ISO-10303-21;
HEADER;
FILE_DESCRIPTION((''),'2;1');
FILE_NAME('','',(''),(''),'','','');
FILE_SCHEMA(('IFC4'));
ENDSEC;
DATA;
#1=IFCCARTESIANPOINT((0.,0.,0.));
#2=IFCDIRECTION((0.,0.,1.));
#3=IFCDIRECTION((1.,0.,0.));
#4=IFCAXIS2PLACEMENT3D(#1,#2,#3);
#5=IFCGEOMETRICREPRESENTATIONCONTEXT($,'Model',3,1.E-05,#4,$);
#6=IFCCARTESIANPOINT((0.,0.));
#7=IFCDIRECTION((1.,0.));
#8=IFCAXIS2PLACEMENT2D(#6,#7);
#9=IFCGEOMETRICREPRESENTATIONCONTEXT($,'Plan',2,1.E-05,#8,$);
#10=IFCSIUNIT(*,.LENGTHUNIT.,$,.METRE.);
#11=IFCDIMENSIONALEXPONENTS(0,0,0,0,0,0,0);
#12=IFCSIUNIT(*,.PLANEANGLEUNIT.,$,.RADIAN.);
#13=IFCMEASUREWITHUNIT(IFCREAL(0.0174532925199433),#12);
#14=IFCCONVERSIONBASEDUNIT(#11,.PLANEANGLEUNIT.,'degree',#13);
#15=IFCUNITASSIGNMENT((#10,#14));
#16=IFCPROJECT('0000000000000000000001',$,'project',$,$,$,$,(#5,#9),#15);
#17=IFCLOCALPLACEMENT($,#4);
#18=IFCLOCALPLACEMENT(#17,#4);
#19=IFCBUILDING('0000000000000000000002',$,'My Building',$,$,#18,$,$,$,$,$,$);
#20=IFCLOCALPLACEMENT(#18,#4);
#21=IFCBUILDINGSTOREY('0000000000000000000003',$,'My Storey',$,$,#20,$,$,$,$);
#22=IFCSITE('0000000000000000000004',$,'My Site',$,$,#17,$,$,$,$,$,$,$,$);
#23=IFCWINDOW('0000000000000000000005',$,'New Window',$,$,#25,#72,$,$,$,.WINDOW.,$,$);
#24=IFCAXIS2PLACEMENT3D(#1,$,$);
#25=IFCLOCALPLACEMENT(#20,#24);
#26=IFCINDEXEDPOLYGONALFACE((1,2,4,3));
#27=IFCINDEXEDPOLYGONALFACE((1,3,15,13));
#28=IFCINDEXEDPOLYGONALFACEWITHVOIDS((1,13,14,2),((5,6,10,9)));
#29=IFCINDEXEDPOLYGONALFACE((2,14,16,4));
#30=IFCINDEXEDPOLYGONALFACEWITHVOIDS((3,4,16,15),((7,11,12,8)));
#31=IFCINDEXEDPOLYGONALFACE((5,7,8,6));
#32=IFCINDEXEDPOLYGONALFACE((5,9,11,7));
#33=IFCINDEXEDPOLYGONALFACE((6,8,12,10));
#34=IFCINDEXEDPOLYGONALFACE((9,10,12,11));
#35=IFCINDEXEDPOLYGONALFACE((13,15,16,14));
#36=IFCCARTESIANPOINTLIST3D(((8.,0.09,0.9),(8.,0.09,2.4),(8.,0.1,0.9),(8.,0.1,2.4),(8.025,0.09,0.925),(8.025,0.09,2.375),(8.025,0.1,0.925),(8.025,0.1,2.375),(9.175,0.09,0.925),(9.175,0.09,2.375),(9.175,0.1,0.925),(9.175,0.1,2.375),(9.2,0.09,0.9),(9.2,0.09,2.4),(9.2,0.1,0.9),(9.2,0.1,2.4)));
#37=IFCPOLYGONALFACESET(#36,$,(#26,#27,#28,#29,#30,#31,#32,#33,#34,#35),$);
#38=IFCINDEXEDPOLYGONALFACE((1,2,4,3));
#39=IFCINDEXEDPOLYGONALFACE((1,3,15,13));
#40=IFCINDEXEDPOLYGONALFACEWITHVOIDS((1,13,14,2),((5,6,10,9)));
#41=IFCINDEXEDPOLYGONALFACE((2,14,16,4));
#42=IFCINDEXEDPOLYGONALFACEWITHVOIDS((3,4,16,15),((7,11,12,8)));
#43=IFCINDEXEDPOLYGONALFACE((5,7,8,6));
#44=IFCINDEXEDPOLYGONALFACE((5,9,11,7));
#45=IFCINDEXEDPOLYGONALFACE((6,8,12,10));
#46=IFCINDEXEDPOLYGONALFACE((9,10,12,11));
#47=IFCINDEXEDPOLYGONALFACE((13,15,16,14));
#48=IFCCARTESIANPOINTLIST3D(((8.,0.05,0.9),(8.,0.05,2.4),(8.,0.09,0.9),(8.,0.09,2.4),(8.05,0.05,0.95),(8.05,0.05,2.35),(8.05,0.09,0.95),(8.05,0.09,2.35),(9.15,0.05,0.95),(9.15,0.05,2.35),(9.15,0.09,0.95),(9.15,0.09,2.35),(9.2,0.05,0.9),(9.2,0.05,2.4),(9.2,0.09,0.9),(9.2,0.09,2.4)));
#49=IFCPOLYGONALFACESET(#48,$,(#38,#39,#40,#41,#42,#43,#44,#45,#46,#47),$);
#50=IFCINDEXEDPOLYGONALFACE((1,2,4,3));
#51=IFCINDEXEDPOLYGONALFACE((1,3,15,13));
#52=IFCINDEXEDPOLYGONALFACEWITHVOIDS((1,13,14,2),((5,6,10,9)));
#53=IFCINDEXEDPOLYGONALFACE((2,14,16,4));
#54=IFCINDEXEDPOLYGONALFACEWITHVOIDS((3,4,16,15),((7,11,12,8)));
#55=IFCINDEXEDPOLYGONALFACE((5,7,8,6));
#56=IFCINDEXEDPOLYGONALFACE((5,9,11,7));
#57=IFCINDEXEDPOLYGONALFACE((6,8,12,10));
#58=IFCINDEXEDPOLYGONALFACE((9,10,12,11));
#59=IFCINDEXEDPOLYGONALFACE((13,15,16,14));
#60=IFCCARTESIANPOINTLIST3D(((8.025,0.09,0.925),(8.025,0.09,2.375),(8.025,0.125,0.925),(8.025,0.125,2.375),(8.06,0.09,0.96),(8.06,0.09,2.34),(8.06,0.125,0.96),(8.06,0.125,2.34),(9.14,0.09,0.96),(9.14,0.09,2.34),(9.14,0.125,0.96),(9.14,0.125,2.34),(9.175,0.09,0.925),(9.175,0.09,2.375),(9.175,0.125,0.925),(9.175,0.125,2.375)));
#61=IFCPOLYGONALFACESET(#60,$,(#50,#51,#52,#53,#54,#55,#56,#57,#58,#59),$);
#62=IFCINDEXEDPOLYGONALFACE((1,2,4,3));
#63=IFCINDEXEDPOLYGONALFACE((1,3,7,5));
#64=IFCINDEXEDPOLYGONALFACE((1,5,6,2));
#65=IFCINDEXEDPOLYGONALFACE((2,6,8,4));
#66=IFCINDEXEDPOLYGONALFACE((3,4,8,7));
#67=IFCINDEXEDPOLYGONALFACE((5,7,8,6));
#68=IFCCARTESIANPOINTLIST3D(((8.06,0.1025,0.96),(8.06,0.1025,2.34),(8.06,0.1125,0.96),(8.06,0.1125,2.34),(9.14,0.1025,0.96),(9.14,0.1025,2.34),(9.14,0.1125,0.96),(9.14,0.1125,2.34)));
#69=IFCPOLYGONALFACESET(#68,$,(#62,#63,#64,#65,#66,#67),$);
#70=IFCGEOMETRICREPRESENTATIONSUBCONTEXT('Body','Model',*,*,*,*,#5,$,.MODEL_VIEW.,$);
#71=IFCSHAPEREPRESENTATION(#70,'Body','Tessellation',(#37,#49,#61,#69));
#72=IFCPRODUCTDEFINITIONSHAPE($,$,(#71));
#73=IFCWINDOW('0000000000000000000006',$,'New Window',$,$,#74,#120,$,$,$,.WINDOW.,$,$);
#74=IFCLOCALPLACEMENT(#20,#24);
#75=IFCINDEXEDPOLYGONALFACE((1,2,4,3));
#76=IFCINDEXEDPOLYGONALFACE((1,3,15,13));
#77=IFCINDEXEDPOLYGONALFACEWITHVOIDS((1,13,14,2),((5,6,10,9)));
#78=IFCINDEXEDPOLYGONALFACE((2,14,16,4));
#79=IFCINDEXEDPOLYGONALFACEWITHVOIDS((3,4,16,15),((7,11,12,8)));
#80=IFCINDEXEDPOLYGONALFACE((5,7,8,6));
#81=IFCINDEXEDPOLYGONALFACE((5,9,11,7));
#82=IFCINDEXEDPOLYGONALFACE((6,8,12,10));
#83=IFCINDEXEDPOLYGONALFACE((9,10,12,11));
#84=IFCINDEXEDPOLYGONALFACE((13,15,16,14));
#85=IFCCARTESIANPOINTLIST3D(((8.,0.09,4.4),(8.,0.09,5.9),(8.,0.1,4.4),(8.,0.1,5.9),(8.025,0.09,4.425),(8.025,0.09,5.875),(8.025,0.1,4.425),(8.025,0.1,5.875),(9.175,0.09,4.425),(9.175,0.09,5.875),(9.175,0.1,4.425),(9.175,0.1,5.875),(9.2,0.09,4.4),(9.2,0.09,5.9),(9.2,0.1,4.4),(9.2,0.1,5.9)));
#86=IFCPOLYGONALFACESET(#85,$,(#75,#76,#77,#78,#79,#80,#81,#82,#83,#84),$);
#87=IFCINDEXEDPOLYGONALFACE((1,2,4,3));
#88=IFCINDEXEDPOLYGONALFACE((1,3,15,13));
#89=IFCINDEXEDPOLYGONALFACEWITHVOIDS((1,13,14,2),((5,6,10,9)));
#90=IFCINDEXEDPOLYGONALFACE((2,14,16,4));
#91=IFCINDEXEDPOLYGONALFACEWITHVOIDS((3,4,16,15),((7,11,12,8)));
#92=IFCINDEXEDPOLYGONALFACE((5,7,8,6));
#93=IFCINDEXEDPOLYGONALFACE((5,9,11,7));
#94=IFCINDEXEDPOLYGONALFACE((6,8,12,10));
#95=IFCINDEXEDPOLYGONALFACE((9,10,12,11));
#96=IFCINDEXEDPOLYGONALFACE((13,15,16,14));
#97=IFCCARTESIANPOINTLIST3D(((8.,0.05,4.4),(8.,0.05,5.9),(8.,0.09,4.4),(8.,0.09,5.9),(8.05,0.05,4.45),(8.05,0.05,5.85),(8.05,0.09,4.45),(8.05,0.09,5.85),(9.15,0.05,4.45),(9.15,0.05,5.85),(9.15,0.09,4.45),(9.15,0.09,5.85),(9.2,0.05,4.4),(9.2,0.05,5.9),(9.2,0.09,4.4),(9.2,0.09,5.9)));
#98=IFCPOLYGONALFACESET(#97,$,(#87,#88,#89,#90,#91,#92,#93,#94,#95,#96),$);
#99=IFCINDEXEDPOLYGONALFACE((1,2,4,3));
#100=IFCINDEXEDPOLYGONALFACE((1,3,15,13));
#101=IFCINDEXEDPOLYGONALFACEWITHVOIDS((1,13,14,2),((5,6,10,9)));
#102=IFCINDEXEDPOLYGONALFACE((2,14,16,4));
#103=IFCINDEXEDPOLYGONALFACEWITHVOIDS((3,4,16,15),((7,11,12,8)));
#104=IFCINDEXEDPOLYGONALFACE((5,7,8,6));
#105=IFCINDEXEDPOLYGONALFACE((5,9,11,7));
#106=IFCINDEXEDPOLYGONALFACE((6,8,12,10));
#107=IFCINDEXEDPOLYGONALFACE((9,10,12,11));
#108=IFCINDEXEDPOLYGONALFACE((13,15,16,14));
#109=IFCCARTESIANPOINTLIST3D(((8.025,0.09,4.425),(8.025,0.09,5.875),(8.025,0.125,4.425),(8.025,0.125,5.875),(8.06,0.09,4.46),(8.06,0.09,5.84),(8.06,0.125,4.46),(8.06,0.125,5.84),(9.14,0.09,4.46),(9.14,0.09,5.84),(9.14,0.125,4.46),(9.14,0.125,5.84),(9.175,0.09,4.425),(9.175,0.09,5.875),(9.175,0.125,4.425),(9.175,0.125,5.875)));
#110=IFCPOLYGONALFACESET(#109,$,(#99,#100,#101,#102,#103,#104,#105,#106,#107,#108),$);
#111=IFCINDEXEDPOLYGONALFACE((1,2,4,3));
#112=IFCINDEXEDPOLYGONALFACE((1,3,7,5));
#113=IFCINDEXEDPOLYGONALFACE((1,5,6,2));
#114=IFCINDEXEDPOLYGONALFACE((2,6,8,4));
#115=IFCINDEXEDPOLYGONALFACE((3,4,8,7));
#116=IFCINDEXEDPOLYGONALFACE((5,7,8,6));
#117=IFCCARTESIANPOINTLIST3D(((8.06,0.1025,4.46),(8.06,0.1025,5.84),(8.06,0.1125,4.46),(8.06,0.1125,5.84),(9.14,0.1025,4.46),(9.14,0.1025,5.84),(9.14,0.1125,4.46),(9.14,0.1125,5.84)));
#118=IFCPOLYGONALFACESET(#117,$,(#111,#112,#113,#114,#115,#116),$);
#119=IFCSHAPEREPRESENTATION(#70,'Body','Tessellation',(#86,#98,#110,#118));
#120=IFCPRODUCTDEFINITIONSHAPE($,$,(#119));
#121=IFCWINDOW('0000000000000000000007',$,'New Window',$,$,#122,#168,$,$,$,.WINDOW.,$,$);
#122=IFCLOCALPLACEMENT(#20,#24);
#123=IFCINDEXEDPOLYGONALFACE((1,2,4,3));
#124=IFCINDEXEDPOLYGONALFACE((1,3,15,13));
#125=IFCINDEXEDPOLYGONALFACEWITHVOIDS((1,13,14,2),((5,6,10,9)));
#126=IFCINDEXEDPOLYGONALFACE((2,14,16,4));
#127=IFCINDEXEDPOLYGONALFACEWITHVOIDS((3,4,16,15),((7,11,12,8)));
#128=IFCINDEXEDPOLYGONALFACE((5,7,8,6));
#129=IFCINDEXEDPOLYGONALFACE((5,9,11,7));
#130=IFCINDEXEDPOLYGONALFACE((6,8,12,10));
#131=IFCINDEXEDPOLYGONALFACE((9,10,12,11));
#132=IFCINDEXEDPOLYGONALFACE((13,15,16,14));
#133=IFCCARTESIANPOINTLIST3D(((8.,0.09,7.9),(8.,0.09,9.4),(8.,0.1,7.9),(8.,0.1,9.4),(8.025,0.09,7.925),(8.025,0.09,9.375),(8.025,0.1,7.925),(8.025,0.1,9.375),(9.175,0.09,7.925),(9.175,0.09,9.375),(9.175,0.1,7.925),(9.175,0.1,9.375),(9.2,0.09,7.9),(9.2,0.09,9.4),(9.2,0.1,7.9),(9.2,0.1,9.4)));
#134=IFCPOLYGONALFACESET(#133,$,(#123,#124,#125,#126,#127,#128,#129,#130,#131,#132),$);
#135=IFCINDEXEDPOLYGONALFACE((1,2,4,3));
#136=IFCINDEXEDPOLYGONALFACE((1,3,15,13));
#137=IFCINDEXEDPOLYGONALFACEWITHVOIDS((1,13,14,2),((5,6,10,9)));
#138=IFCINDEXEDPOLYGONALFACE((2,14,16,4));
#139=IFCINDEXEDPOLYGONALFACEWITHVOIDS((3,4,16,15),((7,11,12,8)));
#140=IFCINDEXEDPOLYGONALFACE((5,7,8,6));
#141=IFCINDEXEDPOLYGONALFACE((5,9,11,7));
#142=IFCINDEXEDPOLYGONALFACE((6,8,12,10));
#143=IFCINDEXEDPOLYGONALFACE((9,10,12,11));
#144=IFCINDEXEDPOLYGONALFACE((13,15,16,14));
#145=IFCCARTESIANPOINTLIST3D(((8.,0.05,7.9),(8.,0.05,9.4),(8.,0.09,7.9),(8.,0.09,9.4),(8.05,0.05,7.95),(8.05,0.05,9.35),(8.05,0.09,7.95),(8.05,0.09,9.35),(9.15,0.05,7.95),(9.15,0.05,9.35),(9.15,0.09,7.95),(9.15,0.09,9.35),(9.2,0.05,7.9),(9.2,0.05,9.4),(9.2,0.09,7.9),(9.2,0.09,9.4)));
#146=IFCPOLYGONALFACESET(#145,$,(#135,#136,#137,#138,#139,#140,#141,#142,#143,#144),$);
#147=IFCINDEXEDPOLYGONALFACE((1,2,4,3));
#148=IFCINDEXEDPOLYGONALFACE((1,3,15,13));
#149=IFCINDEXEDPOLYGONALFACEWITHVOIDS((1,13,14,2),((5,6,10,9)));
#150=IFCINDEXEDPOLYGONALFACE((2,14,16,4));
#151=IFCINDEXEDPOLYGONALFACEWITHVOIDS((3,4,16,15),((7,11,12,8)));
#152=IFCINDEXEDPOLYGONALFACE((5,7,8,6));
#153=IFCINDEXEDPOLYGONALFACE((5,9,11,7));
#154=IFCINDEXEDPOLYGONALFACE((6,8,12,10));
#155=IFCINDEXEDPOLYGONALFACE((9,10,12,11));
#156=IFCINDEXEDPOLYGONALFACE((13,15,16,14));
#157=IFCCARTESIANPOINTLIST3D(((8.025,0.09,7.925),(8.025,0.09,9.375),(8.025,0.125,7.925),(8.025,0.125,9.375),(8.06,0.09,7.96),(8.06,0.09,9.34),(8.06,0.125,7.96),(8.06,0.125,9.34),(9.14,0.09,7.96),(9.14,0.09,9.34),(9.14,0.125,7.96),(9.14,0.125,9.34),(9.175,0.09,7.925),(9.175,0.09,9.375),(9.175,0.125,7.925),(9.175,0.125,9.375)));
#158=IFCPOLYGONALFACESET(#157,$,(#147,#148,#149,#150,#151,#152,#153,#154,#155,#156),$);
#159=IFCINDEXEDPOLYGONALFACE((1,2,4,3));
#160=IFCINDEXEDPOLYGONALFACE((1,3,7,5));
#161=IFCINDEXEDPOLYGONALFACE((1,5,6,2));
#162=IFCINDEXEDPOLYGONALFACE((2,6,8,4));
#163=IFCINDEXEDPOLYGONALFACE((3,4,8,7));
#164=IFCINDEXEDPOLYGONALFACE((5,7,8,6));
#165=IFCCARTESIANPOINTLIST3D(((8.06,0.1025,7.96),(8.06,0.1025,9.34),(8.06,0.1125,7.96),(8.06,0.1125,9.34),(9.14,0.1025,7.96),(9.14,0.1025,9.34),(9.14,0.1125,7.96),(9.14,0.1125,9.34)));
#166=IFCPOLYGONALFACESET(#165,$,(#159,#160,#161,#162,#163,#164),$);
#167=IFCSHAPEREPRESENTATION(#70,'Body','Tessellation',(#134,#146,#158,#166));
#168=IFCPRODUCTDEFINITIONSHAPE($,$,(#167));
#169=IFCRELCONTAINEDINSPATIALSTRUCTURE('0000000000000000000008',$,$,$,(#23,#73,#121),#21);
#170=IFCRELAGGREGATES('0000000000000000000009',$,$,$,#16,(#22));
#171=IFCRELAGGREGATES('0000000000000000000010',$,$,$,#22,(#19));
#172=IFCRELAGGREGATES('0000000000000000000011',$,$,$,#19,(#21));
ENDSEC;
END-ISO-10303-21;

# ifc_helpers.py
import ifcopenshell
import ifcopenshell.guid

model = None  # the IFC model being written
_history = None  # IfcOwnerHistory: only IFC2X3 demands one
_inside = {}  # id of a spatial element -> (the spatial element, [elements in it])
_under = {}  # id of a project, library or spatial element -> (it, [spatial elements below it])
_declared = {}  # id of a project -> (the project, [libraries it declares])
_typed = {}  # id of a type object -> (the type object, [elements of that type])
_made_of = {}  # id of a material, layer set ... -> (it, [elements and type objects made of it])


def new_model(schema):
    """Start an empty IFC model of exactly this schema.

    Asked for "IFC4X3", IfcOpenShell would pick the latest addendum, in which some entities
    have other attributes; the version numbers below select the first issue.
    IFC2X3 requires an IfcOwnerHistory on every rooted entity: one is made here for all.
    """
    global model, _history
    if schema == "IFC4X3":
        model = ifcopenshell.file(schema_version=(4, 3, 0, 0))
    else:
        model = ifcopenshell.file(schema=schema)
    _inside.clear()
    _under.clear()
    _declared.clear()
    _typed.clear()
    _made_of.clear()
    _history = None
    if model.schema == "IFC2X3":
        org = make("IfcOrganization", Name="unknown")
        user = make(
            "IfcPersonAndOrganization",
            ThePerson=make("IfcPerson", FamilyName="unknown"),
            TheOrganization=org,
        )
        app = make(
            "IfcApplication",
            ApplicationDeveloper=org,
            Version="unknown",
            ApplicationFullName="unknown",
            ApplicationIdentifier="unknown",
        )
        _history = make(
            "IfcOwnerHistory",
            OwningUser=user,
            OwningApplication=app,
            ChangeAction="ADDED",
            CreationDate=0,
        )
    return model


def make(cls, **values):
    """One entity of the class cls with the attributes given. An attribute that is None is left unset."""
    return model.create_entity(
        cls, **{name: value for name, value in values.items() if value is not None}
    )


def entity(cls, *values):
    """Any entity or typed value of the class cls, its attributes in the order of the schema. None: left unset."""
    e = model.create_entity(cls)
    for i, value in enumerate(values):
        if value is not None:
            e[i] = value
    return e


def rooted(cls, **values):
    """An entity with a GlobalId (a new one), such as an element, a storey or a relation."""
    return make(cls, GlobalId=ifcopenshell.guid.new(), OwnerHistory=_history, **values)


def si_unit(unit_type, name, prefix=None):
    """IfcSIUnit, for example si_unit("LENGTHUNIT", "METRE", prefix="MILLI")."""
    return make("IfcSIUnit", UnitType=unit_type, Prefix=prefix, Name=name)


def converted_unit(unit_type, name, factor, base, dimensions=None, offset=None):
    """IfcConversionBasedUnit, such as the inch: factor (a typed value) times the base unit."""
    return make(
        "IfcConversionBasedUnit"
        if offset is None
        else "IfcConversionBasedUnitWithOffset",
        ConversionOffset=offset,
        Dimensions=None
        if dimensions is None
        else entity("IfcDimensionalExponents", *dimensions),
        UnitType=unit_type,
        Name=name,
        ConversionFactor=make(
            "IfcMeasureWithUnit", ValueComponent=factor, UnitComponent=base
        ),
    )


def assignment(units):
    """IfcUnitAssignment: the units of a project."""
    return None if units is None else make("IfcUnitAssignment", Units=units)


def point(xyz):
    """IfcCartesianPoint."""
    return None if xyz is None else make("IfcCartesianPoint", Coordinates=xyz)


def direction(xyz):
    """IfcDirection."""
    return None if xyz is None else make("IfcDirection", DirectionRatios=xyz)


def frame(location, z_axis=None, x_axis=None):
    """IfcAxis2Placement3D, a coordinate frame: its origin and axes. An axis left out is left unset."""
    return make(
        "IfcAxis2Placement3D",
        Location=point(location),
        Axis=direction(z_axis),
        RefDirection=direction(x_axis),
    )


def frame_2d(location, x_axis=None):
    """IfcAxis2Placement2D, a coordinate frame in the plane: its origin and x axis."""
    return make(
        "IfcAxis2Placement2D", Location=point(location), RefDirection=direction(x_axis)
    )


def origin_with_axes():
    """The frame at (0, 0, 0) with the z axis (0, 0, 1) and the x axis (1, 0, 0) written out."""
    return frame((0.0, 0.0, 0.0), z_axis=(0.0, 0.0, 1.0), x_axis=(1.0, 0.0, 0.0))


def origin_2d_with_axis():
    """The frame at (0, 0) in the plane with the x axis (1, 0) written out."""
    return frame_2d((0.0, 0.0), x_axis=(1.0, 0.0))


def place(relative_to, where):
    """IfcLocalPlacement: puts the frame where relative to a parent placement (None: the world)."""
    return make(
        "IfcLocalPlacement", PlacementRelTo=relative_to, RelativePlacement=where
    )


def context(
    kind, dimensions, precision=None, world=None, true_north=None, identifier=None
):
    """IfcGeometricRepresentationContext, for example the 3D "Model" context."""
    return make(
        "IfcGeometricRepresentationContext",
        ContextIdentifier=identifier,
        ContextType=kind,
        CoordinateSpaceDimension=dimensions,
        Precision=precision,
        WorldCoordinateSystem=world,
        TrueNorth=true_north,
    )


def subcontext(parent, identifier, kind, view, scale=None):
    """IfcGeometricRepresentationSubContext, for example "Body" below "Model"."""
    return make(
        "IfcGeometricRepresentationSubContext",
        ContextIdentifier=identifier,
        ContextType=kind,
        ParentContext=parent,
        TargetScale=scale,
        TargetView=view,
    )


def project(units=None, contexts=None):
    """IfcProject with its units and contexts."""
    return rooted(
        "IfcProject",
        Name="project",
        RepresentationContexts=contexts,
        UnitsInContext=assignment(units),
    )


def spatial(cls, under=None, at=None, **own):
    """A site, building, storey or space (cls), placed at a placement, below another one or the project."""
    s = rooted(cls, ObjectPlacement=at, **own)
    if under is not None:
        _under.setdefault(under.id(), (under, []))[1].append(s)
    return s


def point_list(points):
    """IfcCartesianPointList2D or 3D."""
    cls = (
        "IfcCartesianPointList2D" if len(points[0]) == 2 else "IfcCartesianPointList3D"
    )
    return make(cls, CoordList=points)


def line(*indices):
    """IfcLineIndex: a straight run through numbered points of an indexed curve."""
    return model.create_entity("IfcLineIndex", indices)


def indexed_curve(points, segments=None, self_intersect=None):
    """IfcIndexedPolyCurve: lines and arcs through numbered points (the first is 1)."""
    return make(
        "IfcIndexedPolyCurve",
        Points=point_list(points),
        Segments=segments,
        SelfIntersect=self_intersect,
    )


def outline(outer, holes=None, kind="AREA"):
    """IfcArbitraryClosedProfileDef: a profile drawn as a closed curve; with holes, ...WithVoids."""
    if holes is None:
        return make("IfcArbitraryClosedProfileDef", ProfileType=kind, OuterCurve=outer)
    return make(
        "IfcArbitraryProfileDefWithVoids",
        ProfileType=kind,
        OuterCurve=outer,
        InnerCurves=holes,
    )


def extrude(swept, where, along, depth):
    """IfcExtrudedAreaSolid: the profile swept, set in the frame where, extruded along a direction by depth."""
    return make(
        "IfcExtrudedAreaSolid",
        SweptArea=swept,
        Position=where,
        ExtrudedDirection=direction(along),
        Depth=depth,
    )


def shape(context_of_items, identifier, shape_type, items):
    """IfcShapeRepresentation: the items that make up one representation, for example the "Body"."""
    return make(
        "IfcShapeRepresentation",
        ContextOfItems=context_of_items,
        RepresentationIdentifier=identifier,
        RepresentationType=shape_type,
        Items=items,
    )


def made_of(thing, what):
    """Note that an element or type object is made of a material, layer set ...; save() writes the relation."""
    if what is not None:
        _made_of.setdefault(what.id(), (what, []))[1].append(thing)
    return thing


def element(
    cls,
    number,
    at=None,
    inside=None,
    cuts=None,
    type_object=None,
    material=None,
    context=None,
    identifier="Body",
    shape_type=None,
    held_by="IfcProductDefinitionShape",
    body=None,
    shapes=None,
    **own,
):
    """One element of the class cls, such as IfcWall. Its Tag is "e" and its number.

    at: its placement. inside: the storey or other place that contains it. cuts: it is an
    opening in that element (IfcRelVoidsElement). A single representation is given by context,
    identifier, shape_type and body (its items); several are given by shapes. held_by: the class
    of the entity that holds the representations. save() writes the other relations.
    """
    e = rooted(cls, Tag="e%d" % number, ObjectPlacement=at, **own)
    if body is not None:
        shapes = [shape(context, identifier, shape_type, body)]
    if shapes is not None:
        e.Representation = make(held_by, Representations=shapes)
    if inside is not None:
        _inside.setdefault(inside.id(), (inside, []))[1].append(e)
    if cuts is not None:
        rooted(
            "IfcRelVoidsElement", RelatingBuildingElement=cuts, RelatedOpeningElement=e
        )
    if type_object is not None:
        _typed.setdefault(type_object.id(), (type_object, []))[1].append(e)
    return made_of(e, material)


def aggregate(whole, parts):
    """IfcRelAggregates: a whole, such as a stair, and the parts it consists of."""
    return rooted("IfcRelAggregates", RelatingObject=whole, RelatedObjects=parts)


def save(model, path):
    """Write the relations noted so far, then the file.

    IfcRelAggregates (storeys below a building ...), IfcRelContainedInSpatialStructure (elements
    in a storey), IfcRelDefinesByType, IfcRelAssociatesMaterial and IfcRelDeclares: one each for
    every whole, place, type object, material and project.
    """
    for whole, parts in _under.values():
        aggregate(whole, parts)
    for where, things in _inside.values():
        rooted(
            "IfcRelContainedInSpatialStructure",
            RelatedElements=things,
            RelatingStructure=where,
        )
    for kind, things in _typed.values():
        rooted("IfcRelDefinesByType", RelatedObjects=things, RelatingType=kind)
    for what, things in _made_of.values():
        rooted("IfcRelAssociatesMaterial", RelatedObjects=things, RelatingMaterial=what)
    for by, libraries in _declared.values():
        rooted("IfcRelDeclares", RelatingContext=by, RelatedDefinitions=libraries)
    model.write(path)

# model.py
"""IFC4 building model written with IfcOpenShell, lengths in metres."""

from ifc_helpers import new_model, entity, si_unit, converted_unit, frame, origin_with_axes, origin_2d_with_axis, place, context, subcontext, project, spatial, line, indexed_curve, outline, extrude, element, save


model = new_model("IFC4")

# Units and contexts
model_context = context("Model", 3, precision=1e-05, world=origin_with_axes())
plan_context = context("Plan", 2, precision=1e-05, world=origin_2d_with_axis())
body_context = subcontext(model_context, "Body", "Model", "MODEL_VIEW")
ifc_project = project(units=[si_unit("LENGTHUNIT", "METRE"), converted_unit("PLANEANGLEUNIT", "degree", entity("IfcReal", 0.0174532925199433), si_unit("PLANEANGLEUNIT", "RADIAN"), dimensions=[0, 0, 0, 0, 0, 0, 0])], contexts=[model_context, plan_context])

# Site, building, storey
site_placement = place(None, origin_with_axes())
site = spatial("IfcSite", under=ifc_project, at=site_placement, Name="My Site")
building_placement = place(site_placement, origin_with_axes())
building = spatial("IfcBuilding", under=site, at=building_placement, Name="My Building")
storey_placement = place(building_placement, origin_with_axes())
storey = spatial("IfcBuildingStorey", under=building, at=storey_placement, Name="My Storey")

# Windows
for number, where, z_axis, x_axis, name in (
    (1, (8.0, 0.0, 0.9), (0.0, 0.0, 1.0), (1.0, 0.0, 0.0), "New Window"),
    (2, (8.0, 0.0, 4.4), (0.0, 0.0, 1.0), (1.0, 0.0, 0.0), "New Window"),
    (3, (8.0, 0.0, 7.9), (0.0, 0.0, 1.0), (1.0, 0.0, 0.0), "New Window"),
):
    element("IfcWindow", number, at=place(storey_placement, frame(where, z_axis=z_axis, x_axis=x_axis)), inside=storey, Name=name, PredefinedType="WINDOW", context=body_context, shape_type="SweptSolid", body=[
        extrude(outline(indexed_curve([(0.0, 0.0), (1.2, 0.0), (1.2, 1.5), (0.0, 1.5)], segments=[line(1, 2, 3, 4, 1)]), holes=[indexed_curve([(0.025, 0.025), (1.175, 0.025), (1.175, 1.475), (0.025, 1.475)], segments=[line(1, 2, 3, 4, 1)])]), frame((0.0, 0.09, 0.0), z_axis=(0.0, -1.0, 0.0), x_axis=(1.0, 0.0, 0.0)), (0.0, 0.0, -1.0), 0.01),
        extrude(outline(indexed_curve([(0.0, 0.0), (1.2, 0.0), (1.2, 1.5), (0.0, 1.5)], segments=[line(1, 2, 3, 4, 1)]), holes=[indexed_curve([(0.05, 0.05), (1.15, 0.05), (1.15, 1.45), (0.05, 1.45)], segments=[line(1, 2, 3, 4, 1)])]), frame((0.0, 0.05, 0.0), z_axis=(0.0, -1.0, 0.0), x_axis=(1.0, 0.0, 0.0)), (0.0, 0.0, -1.0), 0.04),
        extrude(outline(indexed_curve([(0.0, 0.0), (1.15, 0.0), (1.15, 1.45), (0.0, 1.45)], segments=[line(1, 2, 3, 4, 1)]), holes=[indexed_curve([(0.035, 0.035), (1.115, 0.035), (1.115, 1.415), (0.035, 1.415)], segments=[line(1, 2, 3, 4, 1)])]), frame((0.025, 0.09, 0.025), z_axis=(0.0, -1.0, 0.0), x_axis=(1.0, 0.0, 0.0)), (0.0, 0.0, -1.0), 0.035),
        extrude(outline(indexed_curve([(0.035, 0.035), (1.115, 0.035), (1.115, 1.415), (0.035, 1.415)], segments=[line(1, 2, 3, 4, 1)])), frame((0.025, 0.1025, 0.025), z_axis=(0.0, -1.0, 0.0), x_axis=(1.0, 0.0, 0.0)), (0.0, 0.0, -1.0), 0.01),
    ])

save(model, "model.ifc")
